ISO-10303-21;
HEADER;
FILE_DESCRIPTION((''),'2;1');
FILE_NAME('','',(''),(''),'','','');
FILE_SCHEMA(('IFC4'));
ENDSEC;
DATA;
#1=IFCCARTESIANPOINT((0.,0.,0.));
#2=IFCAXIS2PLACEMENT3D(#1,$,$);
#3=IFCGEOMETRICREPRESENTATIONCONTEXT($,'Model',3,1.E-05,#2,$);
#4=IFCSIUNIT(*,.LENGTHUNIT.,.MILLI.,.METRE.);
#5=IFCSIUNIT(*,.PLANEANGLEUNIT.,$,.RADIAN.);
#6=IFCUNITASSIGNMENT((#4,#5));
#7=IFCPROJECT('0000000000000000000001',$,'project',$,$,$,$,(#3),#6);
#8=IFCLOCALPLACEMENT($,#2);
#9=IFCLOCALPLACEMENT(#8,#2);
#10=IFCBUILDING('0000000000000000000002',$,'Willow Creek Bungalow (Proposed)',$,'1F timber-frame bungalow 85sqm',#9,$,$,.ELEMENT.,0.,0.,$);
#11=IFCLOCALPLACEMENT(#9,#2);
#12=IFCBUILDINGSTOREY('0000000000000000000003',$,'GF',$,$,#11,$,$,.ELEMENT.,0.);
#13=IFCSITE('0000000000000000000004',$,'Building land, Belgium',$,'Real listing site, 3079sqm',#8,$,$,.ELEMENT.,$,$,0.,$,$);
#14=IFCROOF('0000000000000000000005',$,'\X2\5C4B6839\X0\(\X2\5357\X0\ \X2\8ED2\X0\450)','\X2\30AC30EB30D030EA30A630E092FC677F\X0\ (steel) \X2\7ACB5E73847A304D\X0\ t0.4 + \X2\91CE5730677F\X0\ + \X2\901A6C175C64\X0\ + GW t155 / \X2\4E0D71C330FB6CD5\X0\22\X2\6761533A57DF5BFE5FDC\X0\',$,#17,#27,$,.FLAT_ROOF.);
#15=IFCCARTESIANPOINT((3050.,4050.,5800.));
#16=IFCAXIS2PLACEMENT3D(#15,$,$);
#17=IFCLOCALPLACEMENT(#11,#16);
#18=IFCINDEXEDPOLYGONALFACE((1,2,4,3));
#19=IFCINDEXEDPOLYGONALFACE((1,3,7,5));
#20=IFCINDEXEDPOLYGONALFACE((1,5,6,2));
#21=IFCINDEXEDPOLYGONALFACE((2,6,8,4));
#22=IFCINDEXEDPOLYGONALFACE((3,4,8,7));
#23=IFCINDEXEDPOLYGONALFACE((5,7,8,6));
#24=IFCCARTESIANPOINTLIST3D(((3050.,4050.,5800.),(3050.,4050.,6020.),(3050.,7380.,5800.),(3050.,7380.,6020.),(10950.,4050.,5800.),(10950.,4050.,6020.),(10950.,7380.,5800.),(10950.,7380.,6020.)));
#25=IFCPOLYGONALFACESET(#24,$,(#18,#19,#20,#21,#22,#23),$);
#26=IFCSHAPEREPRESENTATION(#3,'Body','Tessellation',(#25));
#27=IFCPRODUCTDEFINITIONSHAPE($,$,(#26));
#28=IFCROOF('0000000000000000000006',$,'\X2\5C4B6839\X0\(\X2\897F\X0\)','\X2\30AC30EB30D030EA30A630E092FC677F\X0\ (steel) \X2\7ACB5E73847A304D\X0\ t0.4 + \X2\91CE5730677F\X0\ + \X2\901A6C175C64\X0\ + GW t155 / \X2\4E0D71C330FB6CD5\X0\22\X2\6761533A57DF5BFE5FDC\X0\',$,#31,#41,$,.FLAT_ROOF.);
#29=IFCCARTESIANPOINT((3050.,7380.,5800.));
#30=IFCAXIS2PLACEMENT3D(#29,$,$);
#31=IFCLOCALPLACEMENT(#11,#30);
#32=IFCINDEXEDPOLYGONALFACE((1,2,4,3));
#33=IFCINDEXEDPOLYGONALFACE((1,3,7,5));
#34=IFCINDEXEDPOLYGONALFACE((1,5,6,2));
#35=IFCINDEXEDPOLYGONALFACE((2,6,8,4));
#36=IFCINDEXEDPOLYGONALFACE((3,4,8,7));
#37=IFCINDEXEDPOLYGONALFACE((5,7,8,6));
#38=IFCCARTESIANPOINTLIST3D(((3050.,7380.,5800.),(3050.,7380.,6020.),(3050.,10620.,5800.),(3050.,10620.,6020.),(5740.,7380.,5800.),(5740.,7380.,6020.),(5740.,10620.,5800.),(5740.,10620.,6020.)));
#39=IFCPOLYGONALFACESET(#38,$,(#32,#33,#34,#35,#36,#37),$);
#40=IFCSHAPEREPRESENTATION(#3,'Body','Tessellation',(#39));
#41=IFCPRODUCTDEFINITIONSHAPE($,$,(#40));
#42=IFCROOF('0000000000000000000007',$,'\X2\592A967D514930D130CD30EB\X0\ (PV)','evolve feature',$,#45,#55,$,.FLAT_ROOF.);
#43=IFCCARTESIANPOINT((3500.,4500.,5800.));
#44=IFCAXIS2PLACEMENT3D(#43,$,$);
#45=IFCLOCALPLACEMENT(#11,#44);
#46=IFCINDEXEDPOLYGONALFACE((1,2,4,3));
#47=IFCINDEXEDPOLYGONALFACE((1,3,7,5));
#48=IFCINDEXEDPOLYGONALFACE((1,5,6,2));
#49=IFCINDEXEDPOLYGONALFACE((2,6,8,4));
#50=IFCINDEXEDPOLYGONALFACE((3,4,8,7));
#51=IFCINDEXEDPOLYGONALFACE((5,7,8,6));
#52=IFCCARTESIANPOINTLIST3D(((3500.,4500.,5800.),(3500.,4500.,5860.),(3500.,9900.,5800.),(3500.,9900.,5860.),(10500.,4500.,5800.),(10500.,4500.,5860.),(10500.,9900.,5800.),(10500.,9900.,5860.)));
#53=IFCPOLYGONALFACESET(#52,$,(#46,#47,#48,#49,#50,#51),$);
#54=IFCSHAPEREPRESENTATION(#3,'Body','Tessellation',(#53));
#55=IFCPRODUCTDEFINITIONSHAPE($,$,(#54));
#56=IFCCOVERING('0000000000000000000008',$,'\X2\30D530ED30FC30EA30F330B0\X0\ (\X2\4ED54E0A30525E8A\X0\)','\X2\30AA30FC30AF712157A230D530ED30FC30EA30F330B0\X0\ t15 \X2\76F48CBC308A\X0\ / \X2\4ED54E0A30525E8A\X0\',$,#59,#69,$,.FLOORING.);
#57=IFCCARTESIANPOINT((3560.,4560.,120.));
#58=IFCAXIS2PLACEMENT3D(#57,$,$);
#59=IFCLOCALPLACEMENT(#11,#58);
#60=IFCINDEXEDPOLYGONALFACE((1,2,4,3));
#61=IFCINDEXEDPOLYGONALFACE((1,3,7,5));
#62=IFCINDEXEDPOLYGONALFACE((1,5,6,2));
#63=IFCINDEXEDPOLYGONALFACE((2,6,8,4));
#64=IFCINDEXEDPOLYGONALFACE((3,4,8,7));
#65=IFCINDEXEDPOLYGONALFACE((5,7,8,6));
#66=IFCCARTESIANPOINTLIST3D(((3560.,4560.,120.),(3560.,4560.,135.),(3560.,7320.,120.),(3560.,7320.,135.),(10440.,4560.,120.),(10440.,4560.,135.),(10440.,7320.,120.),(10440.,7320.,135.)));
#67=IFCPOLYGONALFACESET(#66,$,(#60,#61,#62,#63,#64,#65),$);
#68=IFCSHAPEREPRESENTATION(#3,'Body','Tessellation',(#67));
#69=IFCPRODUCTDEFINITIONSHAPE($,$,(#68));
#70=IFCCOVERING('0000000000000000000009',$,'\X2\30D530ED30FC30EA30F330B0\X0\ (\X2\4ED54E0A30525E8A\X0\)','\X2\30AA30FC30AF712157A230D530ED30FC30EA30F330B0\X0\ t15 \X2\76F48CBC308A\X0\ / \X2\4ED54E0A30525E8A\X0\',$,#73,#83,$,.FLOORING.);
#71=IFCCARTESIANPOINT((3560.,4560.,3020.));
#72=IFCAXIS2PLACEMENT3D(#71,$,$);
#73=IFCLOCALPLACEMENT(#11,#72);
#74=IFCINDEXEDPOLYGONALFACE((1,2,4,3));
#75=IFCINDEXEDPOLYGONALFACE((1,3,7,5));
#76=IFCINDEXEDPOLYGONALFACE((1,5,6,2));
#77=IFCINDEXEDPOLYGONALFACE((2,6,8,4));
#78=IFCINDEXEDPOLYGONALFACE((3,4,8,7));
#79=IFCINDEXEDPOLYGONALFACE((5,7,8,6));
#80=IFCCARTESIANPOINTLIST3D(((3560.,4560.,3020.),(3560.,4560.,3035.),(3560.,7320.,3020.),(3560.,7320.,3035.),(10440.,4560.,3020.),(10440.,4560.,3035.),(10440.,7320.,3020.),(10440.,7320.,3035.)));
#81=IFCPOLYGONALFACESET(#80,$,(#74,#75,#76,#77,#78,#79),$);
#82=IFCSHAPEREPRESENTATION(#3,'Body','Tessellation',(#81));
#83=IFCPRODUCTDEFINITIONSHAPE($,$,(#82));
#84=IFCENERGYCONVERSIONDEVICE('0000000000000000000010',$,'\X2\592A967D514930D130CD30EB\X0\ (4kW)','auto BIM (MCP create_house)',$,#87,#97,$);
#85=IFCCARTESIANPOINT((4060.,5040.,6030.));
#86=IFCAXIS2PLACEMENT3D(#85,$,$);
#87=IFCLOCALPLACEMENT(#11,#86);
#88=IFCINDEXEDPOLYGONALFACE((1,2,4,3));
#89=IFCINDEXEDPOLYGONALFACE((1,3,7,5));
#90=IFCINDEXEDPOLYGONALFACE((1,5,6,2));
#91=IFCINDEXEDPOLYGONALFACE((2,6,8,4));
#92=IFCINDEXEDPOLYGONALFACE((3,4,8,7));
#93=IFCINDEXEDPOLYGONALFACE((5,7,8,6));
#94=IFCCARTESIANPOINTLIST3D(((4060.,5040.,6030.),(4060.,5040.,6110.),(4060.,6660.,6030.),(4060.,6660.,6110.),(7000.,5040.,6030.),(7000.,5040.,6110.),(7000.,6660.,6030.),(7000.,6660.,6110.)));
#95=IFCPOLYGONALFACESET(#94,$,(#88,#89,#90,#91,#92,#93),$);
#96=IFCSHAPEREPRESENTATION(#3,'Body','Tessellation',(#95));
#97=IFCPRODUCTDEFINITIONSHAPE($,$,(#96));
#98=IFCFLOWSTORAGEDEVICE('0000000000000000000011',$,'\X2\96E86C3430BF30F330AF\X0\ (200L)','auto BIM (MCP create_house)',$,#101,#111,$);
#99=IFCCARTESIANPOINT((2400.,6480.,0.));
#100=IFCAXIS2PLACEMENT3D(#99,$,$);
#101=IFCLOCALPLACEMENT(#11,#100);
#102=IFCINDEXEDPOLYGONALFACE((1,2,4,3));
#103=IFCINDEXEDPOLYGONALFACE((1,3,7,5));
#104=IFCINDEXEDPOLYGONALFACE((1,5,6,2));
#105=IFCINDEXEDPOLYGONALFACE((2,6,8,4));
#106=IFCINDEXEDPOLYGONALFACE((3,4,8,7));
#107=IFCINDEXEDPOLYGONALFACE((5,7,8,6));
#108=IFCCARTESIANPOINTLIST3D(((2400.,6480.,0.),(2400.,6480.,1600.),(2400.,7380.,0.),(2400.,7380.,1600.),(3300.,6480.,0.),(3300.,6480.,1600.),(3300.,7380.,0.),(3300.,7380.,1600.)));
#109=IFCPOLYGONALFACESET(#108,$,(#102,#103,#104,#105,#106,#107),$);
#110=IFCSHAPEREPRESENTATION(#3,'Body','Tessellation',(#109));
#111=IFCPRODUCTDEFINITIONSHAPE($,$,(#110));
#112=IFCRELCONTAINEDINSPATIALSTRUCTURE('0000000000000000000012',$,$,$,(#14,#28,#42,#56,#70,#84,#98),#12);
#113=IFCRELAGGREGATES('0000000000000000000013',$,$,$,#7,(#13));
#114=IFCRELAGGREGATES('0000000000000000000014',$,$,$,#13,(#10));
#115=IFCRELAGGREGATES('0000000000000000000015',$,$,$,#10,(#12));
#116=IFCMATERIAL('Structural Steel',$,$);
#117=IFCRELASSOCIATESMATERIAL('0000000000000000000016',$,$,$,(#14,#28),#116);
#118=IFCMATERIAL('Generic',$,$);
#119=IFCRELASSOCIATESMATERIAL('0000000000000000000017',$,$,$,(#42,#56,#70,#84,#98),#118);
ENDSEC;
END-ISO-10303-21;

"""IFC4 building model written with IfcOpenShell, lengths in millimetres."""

from ifc_helpers import new_model, si_unit, frame, frame_2d, origin, place, context, project, spatial, rectangle, extrude, material, element, save


model = new_model("IFC4")

# Units and contexts
model_context = context("Model", 3, precision=1e-05, world=origin())
ifc_project = project(units=[si_unit("LENGTHUNIT", "METRE", prefix="MILLI"), si_unit("PLANEANGLEUNIT", "RADIAN")], contexts=[model_context])

# Site, building, storey
site_placement = place(None, origin())
site = spatial("IfcSite", under=ifc_project, at=site_placement, Name="Building land, Belgium", ObjectType="Real listing site, 3079sqm", CompositionType="ELEMENT", RefElevation=0.0)
building_placement = place(site_placement, origin())
building = spatial("IfcBuilding", under=site, at=building_placement, Name="Willow Creek Bungalow (Proposed)", ObjectType="1F timber-frame bungalow 85sqm", CompositionType="ELEMENT", ElevationOfRefHeight=0.0, ElevationOfTerrain=0.0)
storey_placement = place(building_placement, origin())
storey = spatial("IfcBuildingStorey", under=building, at=storey_placement, Name="GF", CompositionType="ELEMENT", Elevation=0.0)

# Shared definitions
ifc_material_1 = material(Name="Generic")

# Roofs
ifc_material_2 = material(Name="Structural Steel")
roof_1_placement = place(storey_placement, frame((3050.0, 4050.0, 5800.0)))
element("IfcRoof", 1, at=roof_1_placement, inside=storey, material=ifc_material_2, Name="屋根(南 軒450)", Description="ガルバリウム鋼板 (steel) 立平葺き t0.4 + 野地板 + 通気層 + GW t155 / 不燃・法22条区域対応", PredefinedType="FLAT_ROOF", context=model_context, shape_type="SweptSolid", body=[
    extrude(rectangle(XDim=7900.0, YDim=3330.0, at=frame_2d((3950.0, 1665.0))), frame((3050.0, 4050.0, 5800.0)), (0.0, 0.0, 1.0), 220.0),
])
roof_2_placement = place(storey_placement, frame((3050.0, 7380.0, 5800.0)))
element("IfcRoof", 2, at=roof_2_placement, inside=storey, material=ifc_material_2, Name="屋根(西)", Description="ガルバリウム鋼板 (steel) 立平葺き t0.4 + 野地板 + 通気層 + GW t155 / 不燃・法22条区域対応", PredefinedType="FLAT_ROOF", context=model_context, shape_type="SweptSolid", body=[
    extrude(rectangle(XDim=2690.0, YDim=3240.0, at=frame_2d((1345.0, 1620.0))), frame((3050.0, 7380.0, 5800.0)), (0.0, 0.0, 1.0), 220.0),
])
roof_3_placement = place(storey_placement, frame((3500.0, 4500.0, 5800.0)))
element("IfcRoof", 3, at=roof_3_placement, inside=storey, material=ifc_material_1, Name="太陽光パネル (PV)", Description="evolve feature", PredefinedType="FLAT_ROOF", context=model_context, shape_type="SweptSolid", body=[
    extrude(rectangle(XDim=7000.0, YDim=5400.0, at=frame_2d((3500.0, 2700.0))), frame((3500.0, 4500.0, 5800.0)), (0.0, 0.0, 1.0), 60.0),
])

# Coverings
covering_1_placement = place(storey_placement, frame((3560.0, 4560.0, 120.0)))
element("IfcCovering", 4, at=covering_1_placement, inside=storey, material=ifc_material_1, Name="フローリング (仕上げ床)", Description="オーク無垢フローリング t15 直貼り / 仕上げ床", PredefinedType="FLOORING", context=model_context, shape_type="SweptSolid", body=[
    extrude(rectangle(XDim=6880.0, YDim=2760.0, at=frame_2d((3440.0, 1380.0))), frame((3560.0, 4560.0, 120.0)), (0.0, 0.0, 1.0), 15.0),
])
covering_2_placement = place(storey_placement, frame((3560.0, 4560.0, 3020.0)))
element("IfcCovering", 5, at=covering_2_placement, inside=storey, material=ifc_material_1, Name="フローリング (仕上げ床)", Description="オーク無垢フローリング t15 直貼り / 仕上げ床", PredefinedType="FLOORING", context=model_context, shape_type="SweptSolid", body=[
    extrude(rectangle(XDim=6880.0, YDim=2760.0, at=frame_2d((3440.0, 1380.0))), frame((3560.0, 4560.0, 3020.0)), (0.0, 0.0, 1.0), 15.0),
])

# Energy conversion device
energy_conversion_device_placement = place(storey_placement, frame((4060.0, 5040.0, 6030.0)))
element("IfcEnergyConversionDevice", 6, at=energy_conversion_device_placement, inside=storey, material=ifc_material_1, Name="太陽光パネル (4kW)", Description="auto BIM (MCP create_house)", context=model_context, shape_type="SweptSolid", body=[
    extrude(rectangle(XDim=2940.0, YDim=1620.0, at=frame_2d((1470.0, 810.0))), frame((4060.0, 5040.0, 6030.0)), (0.0, 0.0, 1.0), 80.0),
])

# Flow storage device
flow_storage_device_placement = place(storey_placement, frame((2400.0, 6480.0, 0.0)))
element("IfcFlowStorageDevice", 7, at=flow_storage_device_placement, inside=storey, material=ifc_material_1, Name="雨水タンク (200L)", Description="auto BIM (MCP create_house)", context=model_context, shape_type="SweptSolid", body=[
    extrude(rectangle(XDim=900.0, YDim=900.0, at=frame_2d((450.0, 450.0))), frame((2400.0, 6480.0, 0.0)), (0.0, 0.0, 1.0), 1600.0),
])

save(model, "model.ifc")
